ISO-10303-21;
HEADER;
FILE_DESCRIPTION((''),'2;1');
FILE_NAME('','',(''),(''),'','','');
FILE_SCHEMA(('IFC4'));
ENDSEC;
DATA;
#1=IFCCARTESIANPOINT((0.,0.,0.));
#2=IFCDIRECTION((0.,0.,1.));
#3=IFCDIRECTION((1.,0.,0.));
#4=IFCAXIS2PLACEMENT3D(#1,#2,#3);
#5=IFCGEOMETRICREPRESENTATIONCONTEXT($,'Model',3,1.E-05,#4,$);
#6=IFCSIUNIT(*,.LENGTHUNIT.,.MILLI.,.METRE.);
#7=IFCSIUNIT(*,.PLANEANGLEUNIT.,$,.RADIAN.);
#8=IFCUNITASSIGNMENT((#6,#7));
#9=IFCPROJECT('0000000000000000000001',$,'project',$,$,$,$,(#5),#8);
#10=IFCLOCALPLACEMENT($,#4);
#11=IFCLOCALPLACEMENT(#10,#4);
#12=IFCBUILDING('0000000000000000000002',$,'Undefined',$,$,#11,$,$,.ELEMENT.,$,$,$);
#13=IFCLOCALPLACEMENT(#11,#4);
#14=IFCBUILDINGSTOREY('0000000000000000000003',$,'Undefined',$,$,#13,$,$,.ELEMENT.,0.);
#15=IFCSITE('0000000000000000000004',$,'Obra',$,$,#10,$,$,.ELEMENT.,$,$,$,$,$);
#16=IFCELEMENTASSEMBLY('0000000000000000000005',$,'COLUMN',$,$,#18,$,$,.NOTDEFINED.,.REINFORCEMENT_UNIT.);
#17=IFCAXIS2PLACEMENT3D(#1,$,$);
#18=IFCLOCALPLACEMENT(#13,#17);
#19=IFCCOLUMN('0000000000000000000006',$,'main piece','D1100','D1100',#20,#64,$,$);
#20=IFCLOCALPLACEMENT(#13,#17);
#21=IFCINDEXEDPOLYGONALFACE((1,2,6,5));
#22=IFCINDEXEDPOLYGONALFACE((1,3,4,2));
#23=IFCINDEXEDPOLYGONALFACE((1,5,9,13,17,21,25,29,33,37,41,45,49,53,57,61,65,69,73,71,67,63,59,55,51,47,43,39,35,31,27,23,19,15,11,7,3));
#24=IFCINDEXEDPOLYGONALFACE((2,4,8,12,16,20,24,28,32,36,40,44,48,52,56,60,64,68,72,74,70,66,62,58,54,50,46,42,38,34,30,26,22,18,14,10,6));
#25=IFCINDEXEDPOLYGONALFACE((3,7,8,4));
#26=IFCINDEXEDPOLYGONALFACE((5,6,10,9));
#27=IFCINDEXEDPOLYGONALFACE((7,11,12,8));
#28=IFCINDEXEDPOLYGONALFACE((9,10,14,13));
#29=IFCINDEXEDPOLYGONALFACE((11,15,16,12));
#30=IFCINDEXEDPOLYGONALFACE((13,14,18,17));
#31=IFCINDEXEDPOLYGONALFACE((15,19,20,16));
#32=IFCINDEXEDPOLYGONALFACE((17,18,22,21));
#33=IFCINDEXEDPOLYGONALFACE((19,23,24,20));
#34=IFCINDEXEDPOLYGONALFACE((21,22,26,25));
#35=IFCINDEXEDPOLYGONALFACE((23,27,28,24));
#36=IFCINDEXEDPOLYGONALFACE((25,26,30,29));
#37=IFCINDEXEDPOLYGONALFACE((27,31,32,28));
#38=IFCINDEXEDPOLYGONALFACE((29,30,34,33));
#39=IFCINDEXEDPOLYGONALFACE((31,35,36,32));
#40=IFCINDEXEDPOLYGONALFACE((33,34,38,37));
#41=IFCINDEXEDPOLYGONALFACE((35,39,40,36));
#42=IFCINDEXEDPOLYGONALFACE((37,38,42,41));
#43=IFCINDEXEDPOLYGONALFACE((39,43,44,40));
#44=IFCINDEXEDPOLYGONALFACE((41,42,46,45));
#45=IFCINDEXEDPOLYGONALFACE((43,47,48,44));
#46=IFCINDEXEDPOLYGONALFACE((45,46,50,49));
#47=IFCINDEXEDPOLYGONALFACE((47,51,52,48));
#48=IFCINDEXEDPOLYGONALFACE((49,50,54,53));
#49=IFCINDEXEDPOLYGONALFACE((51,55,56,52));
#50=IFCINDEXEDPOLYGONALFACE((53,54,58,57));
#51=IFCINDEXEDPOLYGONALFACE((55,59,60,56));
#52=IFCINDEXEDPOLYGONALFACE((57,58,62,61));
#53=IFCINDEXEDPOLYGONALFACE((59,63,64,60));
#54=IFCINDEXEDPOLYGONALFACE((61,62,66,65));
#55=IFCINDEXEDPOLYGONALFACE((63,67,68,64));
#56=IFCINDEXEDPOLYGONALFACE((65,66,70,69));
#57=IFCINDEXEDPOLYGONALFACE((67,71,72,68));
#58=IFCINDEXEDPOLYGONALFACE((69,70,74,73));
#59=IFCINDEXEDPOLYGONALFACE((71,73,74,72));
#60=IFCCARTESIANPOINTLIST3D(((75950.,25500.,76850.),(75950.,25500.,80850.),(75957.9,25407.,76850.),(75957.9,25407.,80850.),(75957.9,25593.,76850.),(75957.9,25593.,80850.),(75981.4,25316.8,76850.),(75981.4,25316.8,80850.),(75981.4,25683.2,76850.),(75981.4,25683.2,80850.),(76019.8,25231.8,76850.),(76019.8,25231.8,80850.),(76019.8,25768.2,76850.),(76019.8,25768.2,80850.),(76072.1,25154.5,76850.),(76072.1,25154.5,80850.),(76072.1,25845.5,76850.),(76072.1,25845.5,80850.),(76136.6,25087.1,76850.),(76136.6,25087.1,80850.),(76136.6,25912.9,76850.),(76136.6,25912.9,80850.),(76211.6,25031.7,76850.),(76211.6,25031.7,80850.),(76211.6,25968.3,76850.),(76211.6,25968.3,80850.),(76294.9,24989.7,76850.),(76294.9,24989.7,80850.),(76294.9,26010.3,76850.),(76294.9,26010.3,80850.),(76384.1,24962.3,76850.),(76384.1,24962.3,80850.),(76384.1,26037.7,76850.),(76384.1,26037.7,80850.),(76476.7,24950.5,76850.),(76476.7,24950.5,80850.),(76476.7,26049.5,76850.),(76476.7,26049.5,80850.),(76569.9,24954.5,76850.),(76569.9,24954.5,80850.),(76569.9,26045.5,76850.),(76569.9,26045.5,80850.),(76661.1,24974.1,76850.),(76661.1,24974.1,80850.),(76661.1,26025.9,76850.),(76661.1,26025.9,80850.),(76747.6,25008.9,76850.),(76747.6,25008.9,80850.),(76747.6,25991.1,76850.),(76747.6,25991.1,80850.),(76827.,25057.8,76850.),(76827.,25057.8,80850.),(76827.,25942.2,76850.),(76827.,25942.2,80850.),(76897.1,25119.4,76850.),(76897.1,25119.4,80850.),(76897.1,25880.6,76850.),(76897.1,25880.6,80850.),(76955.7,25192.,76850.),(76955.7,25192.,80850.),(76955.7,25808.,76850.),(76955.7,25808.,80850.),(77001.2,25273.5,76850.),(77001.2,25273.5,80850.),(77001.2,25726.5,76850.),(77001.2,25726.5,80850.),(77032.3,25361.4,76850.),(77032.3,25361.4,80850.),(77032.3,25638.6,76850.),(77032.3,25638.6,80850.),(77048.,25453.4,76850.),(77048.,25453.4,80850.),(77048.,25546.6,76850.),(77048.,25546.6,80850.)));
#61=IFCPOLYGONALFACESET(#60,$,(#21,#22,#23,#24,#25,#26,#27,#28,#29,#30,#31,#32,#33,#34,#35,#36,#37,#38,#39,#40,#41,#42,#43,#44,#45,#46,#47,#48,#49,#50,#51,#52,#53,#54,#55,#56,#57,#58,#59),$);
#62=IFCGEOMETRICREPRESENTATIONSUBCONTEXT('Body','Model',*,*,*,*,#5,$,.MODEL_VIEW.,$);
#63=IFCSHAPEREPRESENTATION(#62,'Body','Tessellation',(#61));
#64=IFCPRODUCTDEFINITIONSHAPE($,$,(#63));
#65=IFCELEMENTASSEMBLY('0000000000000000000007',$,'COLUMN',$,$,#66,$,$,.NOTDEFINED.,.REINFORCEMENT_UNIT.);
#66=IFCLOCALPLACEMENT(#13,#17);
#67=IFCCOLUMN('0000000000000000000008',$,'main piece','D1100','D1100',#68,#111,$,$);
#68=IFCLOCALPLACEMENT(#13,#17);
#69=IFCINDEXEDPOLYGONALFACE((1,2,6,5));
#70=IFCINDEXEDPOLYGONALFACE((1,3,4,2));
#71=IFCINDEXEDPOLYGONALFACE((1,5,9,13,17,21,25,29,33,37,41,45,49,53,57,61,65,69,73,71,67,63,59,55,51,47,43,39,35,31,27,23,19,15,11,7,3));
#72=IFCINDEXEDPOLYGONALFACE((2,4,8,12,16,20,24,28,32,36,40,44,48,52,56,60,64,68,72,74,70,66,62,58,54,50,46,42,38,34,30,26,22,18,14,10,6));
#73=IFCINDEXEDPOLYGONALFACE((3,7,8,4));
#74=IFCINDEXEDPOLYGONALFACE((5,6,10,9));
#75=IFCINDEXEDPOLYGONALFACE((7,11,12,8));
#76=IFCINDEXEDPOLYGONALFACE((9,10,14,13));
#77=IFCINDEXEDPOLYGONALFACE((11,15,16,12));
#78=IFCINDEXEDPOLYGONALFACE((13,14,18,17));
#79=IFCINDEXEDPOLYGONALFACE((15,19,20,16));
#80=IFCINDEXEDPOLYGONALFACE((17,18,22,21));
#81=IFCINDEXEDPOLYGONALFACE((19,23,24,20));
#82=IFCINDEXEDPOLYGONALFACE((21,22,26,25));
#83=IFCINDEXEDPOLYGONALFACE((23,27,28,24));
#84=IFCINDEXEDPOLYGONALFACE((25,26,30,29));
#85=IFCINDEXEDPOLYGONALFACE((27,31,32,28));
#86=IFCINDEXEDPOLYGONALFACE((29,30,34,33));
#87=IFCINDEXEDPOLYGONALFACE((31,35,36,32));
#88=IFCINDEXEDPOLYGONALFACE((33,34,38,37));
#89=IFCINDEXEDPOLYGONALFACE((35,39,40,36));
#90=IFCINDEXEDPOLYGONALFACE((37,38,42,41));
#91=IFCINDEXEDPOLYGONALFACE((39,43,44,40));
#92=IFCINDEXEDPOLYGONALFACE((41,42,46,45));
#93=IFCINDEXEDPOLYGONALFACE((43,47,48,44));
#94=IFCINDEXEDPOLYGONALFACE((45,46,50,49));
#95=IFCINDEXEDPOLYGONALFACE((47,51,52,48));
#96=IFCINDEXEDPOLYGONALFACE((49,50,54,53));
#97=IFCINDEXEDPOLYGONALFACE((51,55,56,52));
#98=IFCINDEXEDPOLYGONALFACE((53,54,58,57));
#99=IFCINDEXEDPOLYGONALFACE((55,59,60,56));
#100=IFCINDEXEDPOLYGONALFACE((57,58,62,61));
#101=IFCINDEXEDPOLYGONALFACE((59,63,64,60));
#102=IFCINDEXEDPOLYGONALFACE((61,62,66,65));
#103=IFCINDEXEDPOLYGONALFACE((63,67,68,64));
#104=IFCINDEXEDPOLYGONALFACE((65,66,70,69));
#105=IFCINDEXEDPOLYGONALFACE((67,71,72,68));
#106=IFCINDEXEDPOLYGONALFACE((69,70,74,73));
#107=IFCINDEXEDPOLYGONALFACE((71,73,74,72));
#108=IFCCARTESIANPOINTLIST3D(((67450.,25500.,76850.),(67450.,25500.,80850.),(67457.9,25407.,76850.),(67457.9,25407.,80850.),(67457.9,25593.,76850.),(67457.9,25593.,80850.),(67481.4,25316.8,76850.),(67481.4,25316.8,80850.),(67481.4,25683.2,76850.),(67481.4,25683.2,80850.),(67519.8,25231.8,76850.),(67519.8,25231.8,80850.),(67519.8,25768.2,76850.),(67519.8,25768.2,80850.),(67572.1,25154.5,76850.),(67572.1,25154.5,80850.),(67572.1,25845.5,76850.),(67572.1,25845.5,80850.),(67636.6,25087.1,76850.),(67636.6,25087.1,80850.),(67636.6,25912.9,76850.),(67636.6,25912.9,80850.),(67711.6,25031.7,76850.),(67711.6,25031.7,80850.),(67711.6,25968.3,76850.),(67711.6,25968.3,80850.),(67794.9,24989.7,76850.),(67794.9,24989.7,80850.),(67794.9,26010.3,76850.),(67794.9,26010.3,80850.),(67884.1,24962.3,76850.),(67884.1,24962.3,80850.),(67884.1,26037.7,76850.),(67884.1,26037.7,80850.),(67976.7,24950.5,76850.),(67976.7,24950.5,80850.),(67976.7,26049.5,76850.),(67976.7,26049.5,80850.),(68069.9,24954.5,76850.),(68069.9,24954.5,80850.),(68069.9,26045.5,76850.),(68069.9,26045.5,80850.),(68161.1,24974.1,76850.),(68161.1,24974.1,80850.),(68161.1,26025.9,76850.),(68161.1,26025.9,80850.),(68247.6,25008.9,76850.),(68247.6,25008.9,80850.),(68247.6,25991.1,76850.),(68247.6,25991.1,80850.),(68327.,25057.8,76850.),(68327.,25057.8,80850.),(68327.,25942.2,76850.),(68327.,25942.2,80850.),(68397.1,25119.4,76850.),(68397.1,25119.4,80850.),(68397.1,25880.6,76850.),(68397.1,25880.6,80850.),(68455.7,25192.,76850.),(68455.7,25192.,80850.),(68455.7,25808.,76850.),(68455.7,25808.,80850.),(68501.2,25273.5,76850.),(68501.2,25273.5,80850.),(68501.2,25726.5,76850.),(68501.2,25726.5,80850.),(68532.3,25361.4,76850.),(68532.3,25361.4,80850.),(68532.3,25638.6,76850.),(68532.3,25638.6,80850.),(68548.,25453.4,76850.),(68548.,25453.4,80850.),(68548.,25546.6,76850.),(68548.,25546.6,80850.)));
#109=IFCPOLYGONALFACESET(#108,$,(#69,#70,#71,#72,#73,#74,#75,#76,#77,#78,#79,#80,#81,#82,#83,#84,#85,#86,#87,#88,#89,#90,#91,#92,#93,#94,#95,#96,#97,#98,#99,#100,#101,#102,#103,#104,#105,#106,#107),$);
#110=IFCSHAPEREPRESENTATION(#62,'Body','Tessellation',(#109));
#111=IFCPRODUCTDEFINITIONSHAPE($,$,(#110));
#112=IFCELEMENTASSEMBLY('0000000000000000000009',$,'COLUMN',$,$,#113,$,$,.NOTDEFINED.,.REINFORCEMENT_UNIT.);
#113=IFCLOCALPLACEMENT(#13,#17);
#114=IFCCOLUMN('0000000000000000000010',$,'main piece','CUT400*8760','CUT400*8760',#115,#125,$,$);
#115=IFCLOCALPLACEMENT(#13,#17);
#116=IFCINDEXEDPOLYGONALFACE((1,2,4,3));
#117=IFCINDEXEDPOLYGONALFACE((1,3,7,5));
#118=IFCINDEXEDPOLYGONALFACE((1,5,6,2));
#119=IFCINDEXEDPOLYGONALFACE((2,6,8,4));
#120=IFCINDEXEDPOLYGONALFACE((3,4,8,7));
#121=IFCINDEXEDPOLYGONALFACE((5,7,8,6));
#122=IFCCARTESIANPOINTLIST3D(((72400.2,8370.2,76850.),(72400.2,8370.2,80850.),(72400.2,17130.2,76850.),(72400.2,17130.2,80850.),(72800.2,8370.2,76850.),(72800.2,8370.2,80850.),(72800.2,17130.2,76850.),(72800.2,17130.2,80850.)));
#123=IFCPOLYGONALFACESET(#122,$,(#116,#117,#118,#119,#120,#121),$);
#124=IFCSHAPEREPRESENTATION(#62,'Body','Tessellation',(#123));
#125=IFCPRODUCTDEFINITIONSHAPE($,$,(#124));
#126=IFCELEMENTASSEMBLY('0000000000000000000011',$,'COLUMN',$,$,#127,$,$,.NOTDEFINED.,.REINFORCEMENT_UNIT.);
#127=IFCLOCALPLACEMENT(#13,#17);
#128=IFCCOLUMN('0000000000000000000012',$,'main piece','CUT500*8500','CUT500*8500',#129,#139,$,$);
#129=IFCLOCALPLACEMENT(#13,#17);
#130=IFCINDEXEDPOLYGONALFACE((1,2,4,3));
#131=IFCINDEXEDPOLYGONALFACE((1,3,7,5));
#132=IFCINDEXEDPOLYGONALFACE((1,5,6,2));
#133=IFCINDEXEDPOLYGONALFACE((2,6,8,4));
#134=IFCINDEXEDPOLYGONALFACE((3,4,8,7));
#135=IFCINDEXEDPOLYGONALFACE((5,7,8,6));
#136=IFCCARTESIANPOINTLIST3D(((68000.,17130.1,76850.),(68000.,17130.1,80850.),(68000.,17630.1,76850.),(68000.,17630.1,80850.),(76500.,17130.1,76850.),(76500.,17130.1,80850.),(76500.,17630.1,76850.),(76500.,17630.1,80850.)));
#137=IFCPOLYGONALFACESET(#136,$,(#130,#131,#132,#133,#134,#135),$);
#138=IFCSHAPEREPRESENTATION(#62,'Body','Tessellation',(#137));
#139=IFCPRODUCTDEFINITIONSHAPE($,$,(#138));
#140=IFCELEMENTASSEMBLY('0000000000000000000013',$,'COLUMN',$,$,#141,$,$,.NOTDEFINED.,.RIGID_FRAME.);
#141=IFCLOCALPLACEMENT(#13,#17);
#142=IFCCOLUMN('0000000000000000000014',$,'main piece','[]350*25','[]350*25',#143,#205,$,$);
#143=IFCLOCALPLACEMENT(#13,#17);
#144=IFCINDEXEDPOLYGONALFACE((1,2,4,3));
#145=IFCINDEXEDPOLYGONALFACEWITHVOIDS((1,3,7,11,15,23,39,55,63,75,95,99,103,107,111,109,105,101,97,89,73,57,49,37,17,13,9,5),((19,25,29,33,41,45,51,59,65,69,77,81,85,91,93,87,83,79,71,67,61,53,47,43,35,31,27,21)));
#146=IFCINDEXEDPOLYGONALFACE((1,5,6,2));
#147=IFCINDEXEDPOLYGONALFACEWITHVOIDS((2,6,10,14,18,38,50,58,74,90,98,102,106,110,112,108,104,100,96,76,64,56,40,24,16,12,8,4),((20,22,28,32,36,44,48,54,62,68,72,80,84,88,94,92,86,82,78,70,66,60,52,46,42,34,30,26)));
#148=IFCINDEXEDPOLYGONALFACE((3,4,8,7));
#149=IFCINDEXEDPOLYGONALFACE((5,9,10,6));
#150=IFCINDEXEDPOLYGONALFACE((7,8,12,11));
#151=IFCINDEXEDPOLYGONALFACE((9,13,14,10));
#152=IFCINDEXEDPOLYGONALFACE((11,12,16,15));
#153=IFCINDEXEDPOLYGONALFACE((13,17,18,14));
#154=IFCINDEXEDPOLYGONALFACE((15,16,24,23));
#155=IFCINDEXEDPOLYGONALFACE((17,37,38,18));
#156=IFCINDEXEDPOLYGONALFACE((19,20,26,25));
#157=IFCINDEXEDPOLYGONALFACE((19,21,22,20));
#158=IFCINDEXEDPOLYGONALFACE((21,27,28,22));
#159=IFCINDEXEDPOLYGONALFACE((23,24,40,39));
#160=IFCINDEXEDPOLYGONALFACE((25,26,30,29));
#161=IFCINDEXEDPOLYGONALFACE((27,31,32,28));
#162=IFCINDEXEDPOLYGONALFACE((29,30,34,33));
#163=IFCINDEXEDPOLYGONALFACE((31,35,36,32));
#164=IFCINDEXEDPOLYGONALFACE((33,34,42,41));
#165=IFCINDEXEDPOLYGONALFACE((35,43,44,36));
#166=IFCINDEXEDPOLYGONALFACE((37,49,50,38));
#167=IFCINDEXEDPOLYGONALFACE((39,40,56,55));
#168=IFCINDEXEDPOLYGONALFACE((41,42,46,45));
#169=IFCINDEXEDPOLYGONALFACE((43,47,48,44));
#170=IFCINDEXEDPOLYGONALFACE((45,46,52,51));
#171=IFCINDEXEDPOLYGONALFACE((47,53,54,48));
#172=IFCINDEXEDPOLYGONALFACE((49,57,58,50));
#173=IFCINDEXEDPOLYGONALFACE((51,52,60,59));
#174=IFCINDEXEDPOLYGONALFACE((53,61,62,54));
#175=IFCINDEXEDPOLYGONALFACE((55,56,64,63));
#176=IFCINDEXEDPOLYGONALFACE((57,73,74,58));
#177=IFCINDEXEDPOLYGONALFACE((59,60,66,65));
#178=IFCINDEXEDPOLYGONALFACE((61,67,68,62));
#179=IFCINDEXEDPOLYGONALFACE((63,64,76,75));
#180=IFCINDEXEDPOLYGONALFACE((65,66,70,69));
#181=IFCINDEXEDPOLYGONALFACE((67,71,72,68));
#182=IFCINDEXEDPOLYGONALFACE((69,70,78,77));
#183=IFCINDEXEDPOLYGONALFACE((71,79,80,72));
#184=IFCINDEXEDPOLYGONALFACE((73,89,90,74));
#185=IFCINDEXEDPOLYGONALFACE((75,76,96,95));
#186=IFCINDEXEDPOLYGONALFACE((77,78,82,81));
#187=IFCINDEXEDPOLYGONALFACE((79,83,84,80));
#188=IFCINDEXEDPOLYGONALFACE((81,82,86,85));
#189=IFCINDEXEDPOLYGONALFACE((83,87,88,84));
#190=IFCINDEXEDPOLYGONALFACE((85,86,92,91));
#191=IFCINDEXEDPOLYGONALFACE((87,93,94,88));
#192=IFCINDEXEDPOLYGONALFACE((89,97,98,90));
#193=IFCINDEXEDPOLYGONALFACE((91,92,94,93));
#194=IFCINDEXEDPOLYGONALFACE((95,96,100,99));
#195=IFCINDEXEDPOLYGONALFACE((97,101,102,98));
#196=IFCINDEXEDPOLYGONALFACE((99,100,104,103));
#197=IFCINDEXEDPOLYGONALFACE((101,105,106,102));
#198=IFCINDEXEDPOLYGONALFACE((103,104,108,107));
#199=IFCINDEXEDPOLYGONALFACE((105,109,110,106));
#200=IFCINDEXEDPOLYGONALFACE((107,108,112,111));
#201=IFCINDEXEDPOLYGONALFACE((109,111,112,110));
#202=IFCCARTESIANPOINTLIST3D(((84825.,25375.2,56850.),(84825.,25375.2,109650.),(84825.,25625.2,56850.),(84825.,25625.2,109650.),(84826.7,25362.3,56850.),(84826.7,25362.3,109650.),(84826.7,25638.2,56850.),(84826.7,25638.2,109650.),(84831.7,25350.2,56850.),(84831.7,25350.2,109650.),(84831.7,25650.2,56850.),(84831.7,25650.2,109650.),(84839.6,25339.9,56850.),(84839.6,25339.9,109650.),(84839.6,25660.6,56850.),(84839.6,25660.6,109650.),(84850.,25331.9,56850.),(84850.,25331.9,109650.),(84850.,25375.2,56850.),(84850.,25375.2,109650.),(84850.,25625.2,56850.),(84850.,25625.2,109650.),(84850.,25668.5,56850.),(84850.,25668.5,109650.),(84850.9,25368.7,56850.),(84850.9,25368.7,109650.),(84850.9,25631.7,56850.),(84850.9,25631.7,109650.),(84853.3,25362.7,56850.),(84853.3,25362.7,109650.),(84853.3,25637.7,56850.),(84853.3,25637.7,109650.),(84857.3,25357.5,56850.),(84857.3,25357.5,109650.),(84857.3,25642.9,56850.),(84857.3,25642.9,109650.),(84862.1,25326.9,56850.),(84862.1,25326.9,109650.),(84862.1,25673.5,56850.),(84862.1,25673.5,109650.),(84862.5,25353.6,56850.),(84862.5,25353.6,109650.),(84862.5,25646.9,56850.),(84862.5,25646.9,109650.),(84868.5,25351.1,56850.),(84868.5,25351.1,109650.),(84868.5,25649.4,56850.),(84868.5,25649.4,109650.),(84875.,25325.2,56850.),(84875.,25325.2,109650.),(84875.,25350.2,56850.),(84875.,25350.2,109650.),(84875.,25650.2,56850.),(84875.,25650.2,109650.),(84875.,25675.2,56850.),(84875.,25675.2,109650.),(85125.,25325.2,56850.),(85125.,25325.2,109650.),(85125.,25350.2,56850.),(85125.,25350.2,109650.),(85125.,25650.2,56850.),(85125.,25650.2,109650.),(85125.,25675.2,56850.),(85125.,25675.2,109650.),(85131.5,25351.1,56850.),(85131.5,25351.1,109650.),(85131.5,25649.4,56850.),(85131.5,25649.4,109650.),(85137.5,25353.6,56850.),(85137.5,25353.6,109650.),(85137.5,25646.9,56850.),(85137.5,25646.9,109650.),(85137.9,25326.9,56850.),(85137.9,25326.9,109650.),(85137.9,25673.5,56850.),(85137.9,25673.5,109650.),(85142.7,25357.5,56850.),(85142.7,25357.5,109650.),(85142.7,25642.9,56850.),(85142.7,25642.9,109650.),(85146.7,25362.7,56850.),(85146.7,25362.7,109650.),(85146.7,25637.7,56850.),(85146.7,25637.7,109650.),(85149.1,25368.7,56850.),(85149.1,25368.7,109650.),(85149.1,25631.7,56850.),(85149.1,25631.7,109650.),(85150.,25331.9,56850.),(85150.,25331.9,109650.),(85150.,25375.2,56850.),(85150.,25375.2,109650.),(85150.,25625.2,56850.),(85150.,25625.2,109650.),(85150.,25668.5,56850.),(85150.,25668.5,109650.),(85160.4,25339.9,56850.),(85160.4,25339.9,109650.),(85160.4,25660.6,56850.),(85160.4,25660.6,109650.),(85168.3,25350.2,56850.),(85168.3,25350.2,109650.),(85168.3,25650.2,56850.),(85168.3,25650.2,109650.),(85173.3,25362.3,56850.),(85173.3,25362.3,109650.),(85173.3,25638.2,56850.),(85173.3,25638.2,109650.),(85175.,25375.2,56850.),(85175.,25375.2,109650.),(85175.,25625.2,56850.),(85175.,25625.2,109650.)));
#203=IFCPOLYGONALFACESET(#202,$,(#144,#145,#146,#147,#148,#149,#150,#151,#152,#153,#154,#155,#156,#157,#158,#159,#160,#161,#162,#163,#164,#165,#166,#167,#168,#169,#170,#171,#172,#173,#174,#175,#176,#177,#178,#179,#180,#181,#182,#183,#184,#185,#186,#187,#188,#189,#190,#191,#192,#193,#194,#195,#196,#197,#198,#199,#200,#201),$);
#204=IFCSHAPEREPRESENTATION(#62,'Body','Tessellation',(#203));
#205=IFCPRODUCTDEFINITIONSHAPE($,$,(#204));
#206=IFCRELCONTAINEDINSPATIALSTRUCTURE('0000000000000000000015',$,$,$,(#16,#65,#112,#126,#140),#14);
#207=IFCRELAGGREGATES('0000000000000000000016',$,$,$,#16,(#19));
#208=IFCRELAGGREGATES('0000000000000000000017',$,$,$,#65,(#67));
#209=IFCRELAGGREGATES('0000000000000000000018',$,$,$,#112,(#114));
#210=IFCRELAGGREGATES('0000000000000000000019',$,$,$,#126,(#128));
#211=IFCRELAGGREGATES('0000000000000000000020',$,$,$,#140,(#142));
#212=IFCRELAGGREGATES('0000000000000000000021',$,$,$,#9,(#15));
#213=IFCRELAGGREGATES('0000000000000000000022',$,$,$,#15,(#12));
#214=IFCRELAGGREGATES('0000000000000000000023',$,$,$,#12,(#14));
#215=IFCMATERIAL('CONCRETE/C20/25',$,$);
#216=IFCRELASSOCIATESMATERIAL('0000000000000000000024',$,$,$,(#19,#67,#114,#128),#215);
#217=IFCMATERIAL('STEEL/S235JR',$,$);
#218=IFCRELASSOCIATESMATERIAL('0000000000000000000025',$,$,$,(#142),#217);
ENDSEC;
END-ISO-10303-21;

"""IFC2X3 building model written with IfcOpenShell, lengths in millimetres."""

from ifc_helpers import new_model, si_unit, frame, origin_with_axes, origin_2d_with_axis, place, context, subcontext, project, spatial, rectangle, hollow_rectangle, circle, extrude, material, element, aggregate, save


model = new_model("IFC2X3")

# Units and contexts
model_context = context("Model", 3, precision=1e-05, world=origin_with_axes())
body_context = subcontext(model_context, "Body", "Model", "MODEL_VIEW")
ifc_project = project(units=[si_unit("LENGTHUNIT", "METRE", prefix="MILLI"), si_unit("PLANEANGLEUNIT", "RADIAN")], contexts=[model_context])

# Site, building, storey
site_placement = place(None, origin_with_axes())
site = spatial("IfcSite", under=ifc_project, at=site_placement, Name="Obra", CompositionType="ELEMENT")
building_placement = place(site_placement, origin_with_axes())
building = spatial("IfcBuilding", under=site, at=building_placement, Name="Undefined", CompositionType="ELEMENT")
storey_placement = place(building_placement, origin_with_axes())
storey = spatial("IfcBuildingStorey", under=building, at=storey_placement, Name="Undefined", CompositionType="ELEMENT", Elevation=0.0)

# Element assemblies, columns
assembly_1_placement = place(storey_placement, origin_with_axes())
assembly_1 = element("IfcElementAssembly", 1, at=assembly_1_placement, inside=storey, Name="COLUMN", AssemblyPlace="NOTDEFINED", PredefinedType="REINFORCEMENT_UNIT")
ifc_material_1 = material(Name="CONCRETE/C20/25")
column_1_placement = place(assembly_1_placement, frame((76500.0, 25500.0, 76850.0), z_axis=(0.0, 0.0, 1.0), x_axis=(0.0, 1.0, 0.0)))
column_1 = element("IfcColumn", 2, at=column_1_placement, material=ifc_material_1, Name="main piece", Description="D1100", ObjectType="D1100", context=body_context, shape_type="SweptSolid", body=[
    extrude(circle(Radius=550.0, at=origin_2d_with_axis()), frame((0.0, 0.0, 4000.0), z_axis=(0.0, 0.0, -1.0), x_axis=(0.0, 1.0, 0.0)), (0.0, 0.0, 1.0), 4000.0),
])
aggregate(assembly_1, [column_1])
assembly_2_placement = place(storey_placement, origin_with_axes())
assembly_2 = element("IfcElementAssembly", 3, at=assembly_2_placement, inside=storey, Name="COLUMN", AssemblyPlace="NOTDEFINED", PredefinedType="REINFORCEMENT_UNIT")
column_2_placement = place(assembly_2_placement, frame((68000.0, 25500.0, 76850.0), z_axis=(0.0, 0.0, 1.0), x_axis=(0.0, 1.0, 0.0)))
column_2 = element("IfcColumn", 4, at=column_2_placement, material=ifc_material_1, Name="main piece", Description="D1100", ObjectType="D1100", context=body_context, shape_type="SweptSolid", body=[
    extrude(circle(Radius=550.0, at=origin_2d_with_axis()), frame((0.0, 0.0, 4000.0), z_axis=(0.0, 0.0, -1.0), x_axis=(0.0, 1.0, 0.0)), (0.0, 0.0, 1.0), 4000.0),
])
aggregate(assembly_2, [column_2])
assembly_3_placement = place(storey_placement, origin_with_axes())
assembly_3 = element("IfcElementAssembly", 5, at=assembly_3_placement, inside=storey, Name="COLUMN", AssemblyPlace="NOTDEFINED", PredefinedType="REINFORCEMENT_UNIT")
column_3_placement = place(assembly_3_placement, frame((72600.2, 12750.2, 76850.0), z_axis=(0.0, 0.0, 1.0), x_axis=(0.0, -1.0, 0.0)))
column_3 = element("IfcColumn", 6, at=column_3_placement, material=ifc_material_1, Name="main piece", Description="CUT400*8760", ObjectType="CUT400*8760", context=body_context, shape_type="SweptSolid", body=[
    extrude(rectangle(XDim=400.0, YDim=8760.0, at=origin_2d_with_axis()), frame((0.0, 0.0, 4000.0), z_axis=(0.0, 0.0, -1.0), x_axis=(0.0, 1.0, 0.0)), (0.0, 0.0, 1.0), 4000.0),
])
aggregate(assembly_3, [column_3])
assembly_4_placement = place(storey_placement, origin_with_axes())
assembly_4 = element("IfcElementAssembly", 7, at=assembly_4_placement, inside=storey, Name="COLUMN", AssemblyPlace="NOTDEFINED", PredefinedType="REINFORCEMENT_UNIT")
column_4_placement = place(assembly_4_placement, frame((72250.0, 17380.1, 76850.0), z_axis=(0.0, 0.0, 1.0), x_axis=(-1.0, 0.0, 0.0)))
column_4 = element("IfcColumn", 8, at=column_4_placement, material=ifc_material_1, Name="main piece", Description="CUT500*8500", ObjectType="CUT500*8500", context=body_context, shape_type="SweptSolid", body=[
    extrude(rectangle(XDim=500.0, YDim=8500.0, at=origin_2d_with_axis()), frame((0.0, 0.0, 4000.0), z_axis=(0.0, 0.0, -1.0), x_axis=(0.0, 1.0, 0.0)), (0.0, 0.0, 1.0), 4000.0),
])
aggregate(assembly_4, [column_4])
assembly_5_placement = place(storey_placement, origin_with_axes())
assembly_5 = element("IfcElementAssembly", 9, at=assembly_5_placement, inside=storey, Name="COLUMN", AssemblyPlace="NOTDEFINED", PredefinedType="RIGID_FRAME")
ifc_material_2 = material(Name="STEEL/S235JR")
column_5_placement = place(assembly_5_placement, frame((85000.0, 25500.2, 56850.0), z_axis=(0.0, 0.0, 1.0), x_axis=(0.0, 1.0, 0.0)))
column_5 = element("IfcColumn", 10, at=column_5_placement, material=ifc_material_2, Name="main piece", Description="[]350*25", ObjectType="[]350*25", context=body_context, shape_type="SweptSolid", body=[
    extrude(hollow_rectangle(XDim=350.0, YDim=350.0, WallThickness=25.0, InnerFilletRadius=25.0, OuterFilletRadius=50.0, at=origin_2d_with_axis()), frame((0.0, 0.0, 52800.0), z_axis=(0.0, 0.0, -1.0), x_axis=(0.0, 1.0, 0.0)), (0.0, 0.0, 1.0), 52800.0),
])
aggregate(assembly_5, [column_5])

save(model, "model.ifc")
